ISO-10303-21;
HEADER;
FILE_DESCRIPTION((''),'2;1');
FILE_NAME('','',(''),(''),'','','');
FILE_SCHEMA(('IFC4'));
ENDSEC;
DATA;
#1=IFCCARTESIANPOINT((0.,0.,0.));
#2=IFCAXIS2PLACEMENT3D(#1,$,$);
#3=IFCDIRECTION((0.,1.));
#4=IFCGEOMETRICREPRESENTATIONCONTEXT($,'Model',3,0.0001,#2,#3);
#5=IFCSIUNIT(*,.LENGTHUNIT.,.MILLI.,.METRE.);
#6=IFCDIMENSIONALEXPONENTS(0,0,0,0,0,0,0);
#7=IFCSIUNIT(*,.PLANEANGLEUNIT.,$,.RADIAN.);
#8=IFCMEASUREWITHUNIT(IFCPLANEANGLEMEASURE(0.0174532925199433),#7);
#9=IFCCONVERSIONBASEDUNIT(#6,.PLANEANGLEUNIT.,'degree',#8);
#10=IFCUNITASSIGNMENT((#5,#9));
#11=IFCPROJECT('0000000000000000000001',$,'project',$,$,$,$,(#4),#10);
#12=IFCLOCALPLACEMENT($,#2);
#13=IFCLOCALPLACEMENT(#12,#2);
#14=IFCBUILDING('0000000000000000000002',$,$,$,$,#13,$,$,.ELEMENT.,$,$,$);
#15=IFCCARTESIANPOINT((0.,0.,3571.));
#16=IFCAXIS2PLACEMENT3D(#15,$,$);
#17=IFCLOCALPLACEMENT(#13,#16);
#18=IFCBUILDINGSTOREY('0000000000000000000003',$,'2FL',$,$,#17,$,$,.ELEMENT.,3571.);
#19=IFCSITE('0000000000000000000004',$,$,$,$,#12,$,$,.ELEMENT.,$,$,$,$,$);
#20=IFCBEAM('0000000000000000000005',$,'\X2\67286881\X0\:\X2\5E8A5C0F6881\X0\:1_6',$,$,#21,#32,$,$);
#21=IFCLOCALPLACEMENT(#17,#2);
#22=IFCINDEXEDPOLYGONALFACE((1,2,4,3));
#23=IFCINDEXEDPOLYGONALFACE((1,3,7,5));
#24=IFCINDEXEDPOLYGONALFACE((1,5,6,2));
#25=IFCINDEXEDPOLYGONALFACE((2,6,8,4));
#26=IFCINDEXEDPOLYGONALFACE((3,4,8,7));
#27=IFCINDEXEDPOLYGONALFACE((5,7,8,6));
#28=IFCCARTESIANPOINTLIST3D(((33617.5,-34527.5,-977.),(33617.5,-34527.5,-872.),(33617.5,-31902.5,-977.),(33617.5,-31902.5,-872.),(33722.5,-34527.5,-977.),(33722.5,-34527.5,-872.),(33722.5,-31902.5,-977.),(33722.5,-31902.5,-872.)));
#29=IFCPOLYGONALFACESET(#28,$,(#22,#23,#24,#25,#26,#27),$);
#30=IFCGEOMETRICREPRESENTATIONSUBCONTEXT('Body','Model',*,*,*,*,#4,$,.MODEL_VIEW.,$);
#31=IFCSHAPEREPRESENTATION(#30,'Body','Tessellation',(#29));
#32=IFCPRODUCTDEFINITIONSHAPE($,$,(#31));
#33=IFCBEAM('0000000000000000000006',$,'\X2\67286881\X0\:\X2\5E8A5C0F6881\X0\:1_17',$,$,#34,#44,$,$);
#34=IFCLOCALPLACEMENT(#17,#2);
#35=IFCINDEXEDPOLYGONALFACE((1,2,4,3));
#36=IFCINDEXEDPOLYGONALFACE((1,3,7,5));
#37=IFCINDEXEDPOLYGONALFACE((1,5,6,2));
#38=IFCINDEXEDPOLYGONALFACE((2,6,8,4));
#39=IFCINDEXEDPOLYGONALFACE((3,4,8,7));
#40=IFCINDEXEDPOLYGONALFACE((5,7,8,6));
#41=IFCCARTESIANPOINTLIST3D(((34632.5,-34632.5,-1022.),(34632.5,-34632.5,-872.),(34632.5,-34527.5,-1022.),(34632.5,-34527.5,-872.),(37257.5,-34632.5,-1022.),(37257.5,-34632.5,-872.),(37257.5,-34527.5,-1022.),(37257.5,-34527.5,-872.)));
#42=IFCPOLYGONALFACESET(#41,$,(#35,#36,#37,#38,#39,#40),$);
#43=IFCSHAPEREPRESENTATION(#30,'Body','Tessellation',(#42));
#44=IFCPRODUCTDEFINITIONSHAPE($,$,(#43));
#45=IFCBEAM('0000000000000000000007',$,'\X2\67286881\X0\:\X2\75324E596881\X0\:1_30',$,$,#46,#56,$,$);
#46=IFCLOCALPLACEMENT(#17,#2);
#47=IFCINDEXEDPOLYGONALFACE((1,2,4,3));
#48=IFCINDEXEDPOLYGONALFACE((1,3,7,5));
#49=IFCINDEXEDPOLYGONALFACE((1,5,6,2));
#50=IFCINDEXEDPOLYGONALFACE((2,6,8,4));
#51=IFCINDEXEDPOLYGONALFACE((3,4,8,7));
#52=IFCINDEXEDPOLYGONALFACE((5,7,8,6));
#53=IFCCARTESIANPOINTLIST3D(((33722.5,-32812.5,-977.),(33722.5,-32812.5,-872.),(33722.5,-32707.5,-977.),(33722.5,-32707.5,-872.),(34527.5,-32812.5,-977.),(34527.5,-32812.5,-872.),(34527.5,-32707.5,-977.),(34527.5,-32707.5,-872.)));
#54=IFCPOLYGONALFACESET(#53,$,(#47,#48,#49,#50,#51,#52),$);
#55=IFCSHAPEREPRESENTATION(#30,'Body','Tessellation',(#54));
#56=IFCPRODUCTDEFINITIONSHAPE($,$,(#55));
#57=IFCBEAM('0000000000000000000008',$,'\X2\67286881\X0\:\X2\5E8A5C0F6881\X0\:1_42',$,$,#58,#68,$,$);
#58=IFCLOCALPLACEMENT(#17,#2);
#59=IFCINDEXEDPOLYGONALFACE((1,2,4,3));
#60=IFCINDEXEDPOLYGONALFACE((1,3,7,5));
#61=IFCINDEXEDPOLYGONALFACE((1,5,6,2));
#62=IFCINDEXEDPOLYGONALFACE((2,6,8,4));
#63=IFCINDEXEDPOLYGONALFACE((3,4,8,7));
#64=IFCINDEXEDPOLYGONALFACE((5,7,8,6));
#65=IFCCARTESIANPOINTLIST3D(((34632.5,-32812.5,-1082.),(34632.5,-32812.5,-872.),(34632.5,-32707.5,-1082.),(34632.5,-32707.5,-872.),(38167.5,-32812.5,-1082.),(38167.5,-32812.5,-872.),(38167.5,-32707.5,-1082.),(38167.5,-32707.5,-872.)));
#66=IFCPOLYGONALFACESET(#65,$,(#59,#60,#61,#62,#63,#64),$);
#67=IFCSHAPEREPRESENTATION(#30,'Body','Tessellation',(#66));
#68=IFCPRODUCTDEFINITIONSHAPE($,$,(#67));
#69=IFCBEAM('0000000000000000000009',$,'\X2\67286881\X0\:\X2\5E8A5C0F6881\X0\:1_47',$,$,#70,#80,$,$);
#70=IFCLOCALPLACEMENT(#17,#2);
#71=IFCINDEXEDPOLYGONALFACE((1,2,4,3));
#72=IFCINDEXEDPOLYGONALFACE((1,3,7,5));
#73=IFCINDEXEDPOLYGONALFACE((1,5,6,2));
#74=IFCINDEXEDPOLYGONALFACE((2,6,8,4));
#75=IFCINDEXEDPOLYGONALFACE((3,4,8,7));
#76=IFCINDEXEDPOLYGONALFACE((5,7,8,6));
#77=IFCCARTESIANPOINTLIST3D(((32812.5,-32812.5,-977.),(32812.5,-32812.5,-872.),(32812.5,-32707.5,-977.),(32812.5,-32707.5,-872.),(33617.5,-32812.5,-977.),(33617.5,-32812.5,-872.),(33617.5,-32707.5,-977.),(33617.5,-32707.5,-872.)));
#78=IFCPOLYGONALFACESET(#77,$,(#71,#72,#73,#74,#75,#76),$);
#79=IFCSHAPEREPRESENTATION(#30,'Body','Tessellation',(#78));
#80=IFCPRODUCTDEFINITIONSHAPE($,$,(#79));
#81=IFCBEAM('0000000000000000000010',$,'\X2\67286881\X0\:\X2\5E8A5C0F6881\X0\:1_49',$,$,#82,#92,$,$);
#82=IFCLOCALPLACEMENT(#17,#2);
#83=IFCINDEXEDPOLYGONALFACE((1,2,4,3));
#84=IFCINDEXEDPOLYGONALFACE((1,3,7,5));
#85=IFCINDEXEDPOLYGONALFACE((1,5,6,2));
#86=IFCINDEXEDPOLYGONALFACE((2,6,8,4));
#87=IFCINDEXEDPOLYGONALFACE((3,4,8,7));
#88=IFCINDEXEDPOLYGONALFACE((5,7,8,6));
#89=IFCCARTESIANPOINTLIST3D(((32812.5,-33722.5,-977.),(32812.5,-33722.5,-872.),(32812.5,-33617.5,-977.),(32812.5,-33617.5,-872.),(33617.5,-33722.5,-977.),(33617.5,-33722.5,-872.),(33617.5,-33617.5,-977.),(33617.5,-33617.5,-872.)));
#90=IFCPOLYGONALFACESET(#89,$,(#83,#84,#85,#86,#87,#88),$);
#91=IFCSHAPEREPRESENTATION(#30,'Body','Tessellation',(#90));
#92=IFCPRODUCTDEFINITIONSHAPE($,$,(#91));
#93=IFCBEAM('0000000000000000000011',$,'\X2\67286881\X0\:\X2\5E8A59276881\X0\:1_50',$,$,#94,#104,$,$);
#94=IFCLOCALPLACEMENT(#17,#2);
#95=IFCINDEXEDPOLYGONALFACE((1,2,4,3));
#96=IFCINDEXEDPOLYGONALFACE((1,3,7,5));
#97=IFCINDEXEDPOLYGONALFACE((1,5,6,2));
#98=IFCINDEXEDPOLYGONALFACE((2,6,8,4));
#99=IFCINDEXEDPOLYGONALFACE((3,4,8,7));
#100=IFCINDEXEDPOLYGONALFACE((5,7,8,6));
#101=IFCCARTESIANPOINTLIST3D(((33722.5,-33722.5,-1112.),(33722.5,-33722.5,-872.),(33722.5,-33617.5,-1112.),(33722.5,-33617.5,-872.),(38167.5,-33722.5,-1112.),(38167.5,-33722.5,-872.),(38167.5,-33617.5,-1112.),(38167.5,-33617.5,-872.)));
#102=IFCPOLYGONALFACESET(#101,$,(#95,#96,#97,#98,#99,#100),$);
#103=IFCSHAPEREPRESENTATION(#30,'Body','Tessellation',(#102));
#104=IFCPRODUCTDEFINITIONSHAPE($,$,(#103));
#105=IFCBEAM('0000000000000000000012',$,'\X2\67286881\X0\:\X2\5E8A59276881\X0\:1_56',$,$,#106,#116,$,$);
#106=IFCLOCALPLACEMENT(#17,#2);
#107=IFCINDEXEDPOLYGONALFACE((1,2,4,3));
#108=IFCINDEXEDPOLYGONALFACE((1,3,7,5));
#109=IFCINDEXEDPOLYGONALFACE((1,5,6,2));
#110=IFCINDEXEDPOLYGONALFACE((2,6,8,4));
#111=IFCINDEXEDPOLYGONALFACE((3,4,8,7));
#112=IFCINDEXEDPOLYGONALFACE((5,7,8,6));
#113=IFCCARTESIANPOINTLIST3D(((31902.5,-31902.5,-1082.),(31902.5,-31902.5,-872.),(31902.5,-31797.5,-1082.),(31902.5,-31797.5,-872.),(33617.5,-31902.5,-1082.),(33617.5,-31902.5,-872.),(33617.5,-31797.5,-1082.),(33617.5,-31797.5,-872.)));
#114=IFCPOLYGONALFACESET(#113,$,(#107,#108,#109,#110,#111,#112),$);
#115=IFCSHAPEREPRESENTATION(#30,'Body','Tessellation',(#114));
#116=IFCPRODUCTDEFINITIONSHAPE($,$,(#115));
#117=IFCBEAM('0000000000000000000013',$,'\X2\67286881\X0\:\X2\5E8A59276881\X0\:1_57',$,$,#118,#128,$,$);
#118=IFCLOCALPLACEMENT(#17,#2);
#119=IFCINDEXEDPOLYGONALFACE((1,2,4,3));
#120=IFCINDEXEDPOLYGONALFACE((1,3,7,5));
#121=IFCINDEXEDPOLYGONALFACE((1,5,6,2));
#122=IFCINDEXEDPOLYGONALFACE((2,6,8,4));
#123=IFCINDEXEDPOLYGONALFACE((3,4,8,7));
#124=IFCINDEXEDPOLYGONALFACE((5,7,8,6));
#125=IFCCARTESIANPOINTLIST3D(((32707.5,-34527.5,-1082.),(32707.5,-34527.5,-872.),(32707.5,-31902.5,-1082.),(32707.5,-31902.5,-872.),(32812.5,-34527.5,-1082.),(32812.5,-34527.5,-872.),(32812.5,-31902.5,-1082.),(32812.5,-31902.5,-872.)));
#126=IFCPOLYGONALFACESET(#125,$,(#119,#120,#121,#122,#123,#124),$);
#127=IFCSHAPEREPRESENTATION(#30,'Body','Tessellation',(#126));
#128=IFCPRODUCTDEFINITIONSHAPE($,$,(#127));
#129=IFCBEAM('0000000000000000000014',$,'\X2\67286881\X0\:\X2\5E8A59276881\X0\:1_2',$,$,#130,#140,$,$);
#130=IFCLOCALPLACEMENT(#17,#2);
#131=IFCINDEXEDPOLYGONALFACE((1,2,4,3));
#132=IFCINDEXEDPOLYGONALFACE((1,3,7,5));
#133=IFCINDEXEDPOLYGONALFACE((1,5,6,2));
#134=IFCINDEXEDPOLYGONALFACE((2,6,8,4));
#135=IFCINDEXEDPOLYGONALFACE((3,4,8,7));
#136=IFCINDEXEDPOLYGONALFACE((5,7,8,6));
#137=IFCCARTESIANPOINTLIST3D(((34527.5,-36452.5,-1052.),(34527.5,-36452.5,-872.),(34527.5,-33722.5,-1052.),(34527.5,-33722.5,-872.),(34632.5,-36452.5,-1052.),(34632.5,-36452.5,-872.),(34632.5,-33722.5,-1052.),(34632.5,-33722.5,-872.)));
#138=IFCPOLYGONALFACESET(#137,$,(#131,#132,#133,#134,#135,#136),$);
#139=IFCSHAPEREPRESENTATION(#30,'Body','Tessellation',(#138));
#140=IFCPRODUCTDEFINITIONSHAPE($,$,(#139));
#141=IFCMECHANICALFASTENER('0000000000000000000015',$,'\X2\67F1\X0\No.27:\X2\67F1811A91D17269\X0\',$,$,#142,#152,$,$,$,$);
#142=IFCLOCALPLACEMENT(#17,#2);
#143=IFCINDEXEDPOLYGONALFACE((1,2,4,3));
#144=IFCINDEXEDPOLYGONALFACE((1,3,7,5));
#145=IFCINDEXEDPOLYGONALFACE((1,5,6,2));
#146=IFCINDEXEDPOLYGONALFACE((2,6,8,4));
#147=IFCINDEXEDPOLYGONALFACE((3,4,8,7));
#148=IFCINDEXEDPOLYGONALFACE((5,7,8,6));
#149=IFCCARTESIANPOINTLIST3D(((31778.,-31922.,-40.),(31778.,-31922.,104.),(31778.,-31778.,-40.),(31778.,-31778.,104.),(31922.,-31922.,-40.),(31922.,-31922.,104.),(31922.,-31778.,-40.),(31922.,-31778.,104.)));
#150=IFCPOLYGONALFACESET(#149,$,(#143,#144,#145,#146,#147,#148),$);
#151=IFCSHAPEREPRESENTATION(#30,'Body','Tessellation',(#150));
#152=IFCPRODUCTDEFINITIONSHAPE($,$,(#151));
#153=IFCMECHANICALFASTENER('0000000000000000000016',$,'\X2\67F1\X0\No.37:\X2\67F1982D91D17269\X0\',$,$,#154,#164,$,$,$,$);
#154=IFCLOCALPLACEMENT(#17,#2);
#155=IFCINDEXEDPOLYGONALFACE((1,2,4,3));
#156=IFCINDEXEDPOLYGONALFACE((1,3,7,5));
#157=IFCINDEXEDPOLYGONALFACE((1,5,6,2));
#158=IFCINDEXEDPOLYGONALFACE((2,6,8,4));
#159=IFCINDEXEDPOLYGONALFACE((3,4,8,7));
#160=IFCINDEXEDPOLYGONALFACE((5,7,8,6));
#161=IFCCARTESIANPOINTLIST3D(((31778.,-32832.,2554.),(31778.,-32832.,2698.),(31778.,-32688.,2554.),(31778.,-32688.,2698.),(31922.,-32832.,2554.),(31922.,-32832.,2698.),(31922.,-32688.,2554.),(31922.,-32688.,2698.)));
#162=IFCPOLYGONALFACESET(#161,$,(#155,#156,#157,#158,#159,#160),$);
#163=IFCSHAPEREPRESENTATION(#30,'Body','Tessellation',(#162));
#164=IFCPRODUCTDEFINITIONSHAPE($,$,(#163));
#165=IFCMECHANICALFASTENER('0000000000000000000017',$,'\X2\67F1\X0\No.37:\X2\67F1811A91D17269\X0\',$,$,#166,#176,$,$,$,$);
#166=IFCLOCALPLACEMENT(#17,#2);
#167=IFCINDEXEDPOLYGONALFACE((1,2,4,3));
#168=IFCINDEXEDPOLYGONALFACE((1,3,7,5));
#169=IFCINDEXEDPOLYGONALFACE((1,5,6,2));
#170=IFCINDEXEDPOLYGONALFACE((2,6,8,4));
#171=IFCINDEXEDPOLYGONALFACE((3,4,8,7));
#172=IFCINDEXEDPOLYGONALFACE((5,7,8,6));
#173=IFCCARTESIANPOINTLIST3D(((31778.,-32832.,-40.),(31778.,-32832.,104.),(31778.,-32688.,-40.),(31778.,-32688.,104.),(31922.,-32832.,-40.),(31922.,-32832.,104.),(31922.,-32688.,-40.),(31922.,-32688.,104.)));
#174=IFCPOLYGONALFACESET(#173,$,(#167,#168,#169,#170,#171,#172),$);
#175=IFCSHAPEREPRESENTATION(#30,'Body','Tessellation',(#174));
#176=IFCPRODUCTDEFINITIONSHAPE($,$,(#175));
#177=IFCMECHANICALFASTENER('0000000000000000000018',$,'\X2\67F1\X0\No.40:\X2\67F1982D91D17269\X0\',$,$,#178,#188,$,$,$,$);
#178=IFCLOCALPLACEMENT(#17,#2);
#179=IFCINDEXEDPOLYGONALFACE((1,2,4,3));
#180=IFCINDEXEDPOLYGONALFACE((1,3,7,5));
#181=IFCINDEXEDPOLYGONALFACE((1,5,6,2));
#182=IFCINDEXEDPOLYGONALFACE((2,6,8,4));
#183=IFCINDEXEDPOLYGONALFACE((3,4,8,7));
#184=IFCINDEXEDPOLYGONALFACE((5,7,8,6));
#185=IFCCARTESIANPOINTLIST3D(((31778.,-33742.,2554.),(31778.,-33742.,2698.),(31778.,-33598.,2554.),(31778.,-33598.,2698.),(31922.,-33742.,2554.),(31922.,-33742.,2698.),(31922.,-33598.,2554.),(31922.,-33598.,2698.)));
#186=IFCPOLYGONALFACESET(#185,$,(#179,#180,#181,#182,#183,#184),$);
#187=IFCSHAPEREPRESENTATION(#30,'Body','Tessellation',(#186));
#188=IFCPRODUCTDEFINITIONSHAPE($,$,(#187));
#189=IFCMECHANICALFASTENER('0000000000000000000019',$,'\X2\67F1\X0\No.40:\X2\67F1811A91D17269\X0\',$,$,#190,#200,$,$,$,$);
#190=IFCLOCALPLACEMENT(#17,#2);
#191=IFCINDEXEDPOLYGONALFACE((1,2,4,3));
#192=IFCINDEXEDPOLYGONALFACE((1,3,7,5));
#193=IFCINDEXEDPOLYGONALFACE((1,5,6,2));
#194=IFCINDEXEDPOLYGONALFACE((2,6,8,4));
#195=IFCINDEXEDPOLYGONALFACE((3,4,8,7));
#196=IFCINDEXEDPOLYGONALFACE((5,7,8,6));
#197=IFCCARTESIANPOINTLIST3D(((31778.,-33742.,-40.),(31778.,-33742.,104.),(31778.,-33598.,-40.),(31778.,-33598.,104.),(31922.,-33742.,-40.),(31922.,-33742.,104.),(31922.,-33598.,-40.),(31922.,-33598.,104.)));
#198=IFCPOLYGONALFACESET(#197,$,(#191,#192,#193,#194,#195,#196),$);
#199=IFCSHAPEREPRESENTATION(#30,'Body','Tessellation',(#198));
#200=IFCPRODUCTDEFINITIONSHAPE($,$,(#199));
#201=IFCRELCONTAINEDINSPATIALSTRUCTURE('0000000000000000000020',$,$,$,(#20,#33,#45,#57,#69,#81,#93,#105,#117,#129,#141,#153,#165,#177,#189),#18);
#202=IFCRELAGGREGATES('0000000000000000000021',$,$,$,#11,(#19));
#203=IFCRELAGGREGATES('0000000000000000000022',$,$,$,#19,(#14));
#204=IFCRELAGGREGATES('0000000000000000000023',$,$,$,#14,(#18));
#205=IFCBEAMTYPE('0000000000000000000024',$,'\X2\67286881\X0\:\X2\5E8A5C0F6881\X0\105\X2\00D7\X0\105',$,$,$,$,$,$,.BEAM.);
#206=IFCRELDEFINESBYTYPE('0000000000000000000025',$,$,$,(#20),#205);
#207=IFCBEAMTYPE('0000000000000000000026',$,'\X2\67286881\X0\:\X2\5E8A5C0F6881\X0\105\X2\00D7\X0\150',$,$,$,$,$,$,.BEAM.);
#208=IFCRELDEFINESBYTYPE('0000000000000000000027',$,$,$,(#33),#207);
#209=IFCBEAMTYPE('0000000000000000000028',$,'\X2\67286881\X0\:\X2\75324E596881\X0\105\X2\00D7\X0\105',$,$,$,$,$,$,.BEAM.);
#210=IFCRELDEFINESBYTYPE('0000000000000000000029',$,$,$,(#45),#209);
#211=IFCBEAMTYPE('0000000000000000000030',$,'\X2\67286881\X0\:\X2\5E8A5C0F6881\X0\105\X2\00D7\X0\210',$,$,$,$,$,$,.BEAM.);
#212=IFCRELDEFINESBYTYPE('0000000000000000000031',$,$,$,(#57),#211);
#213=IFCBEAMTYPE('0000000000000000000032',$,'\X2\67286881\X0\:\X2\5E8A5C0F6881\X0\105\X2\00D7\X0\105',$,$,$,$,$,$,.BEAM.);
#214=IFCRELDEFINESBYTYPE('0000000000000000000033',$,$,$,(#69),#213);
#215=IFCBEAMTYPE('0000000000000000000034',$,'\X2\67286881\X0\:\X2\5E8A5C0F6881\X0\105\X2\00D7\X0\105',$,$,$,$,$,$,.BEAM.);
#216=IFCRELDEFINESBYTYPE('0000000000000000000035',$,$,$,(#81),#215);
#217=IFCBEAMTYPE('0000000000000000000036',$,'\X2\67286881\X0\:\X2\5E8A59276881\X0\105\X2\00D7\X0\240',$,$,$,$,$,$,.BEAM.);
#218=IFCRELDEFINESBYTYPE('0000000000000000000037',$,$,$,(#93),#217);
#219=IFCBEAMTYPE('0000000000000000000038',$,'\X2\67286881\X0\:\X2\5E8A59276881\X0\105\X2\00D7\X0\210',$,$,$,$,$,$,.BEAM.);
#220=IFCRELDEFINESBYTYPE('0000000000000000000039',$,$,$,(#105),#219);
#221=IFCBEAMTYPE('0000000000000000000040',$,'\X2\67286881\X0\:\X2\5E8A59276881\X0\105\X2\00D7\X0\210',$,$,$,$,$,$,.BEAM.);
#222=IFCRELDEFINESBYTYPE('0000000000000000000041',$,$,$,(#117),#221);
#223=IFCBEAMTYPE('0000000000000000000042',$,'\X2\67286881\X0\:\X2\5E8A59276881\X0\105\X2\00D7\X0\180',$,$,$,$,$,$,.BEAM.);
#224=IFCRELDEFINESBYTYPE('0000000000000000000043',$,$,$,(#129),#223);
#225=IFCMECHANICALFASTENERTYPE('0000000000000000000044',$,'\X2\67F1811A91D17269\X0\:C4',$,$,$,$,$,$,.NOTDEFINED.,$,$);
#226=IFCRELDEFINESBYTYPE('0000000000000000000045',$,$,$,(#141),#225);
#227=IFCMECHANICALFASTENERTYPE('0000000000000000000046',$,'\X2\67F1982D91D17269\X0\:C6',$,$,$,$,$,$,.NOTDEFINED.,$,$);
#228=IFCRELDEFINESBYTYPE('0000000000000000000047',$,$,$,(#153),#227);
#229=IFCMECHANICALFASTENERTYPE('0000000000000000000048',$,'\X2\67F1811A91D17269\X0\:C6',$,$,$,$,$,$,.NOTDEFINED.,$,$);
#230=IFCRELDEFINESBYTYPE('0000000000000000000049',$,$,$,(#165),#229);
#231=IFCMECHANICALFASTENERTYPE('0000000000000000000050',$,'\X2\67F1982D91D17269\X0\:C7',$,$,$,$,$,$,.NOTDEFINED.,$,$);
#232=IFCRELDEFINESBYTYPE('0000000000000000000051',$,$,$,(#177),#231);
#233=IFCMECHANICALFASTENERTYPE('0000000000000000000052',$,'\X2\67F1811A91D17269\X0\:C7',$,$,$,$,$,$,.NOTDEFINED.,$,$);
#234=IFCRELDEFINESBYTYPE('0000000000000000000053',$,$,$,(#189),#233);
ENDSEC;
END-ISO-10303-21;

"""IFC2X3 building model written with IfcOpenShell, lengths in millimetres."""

from ifc_helpers import new_model, entity, si_unit, converted_unit, direction, frame, origin, origin_with_axes, origin_2d, place, context, subcontext, project, spatial, rectangle, extrude, type_object, element, save


model = new_model("IFC2X3")

# Units and contexts
model_context = context("Model", 3, precision=0.0001, world=origin(), true_north=direction((0.0, 1.0)))
body_context = subcontext(model_context, "Body", "Model", "MODEL_VIEW")
ifc_project = project(units=[si_unit("LENGTHUNIT", "METRE", prefix="MILLI"), converted_unit("PLANEANGLEUNIT", "degree", entity("IfcPlaneAngleMeasure", 0.0174532925199433), si_unit("PLANEANGLEUNIT", "RADIAN"), dimensions=[0, 0, 0, 0, 0, 0, 0])], contexts=[model_context])

# Site, building, storey
site_placement = place(None, origin())
site = spatial("IfcSite", under=ifc_project, at=site_placement, CompositionType="ELEMENT")
building_placement = place(site_placement, origin())
building = spatial("IfcBuilding", under=site, at=building_placement, CompositionType="ELEMENT")
storey_placement = place(building_placement, frame((0.0, 0.0, 3571.0)))
storey = spatial("IfcBuildingStorey", under=building, at=storey_placement, Name="2FL", CompositionType="ELEMENT", Elevation=3571.0)

# Beams
beam_type_1 = type_object("IfcBeamType", Name="木梁:床小梁105×105", PredefinedType="BEAM")
beam_1_placement = place(storey_placement, frame((33670.0, -31902.5, -924.5), z_axis=(0.0, -1.0, 0.0), x_axis=(1.0, 0.0, 0.0)))
element("IfcBeam", 1, at=beam_1_placement, inside=storey, type_object=beam_type_1, Name="木梁:床小梁:1_6", context=body_context, shape_type="SweptSolid", body=[
    extrude(rectangle(XDim=105.0, YDim=105.0, at=origin_2d()), origin_with_axes(), (0.0, 0.0, 1.0), 2625.0),
])
beam_type_2 = type_object("IfcBeamType", Name="木梁:床小梁105×150", PredefinedType="BEAM")
beam_2_placement = place(storey_placement, frame((34632.5, -34580.0, -947.0), z_axis=(1.0, 0.0, 0.0), x_axis=(0.0, 1.0, 0.0)))
element("IfcBeam", 2, at=beam_2_placement, inside=storey, type_object=beam_type_2, Name="木梁:床小梁:1_17", context=body_context, shape_type="SweptSolid", body=[
    extrude(rectangle(XDim=105.0, YDim=150.0, at=origin_2d()), origin_with_axes(), (0.0, 0.0, 1.0), 2625.0),
])
beam_type_3 = type_object("IfcBeamType", Name="木梁:甲乙梁105×105", PredefinedType="BEAM")
beam_3_placement = place(storey_placement, frame((33722.5, -32760.0, -924.5), z_axis=(1.0, 0.0, 0.0), x_axis=(0.0, 1.0, 0.0)))
element("IfcBeam", 3, at=beam_3_placement, inside=storey, type_object=beam_type_3, Name="木梁:甲乙梁:1_30", context=body_context, shape_type="SweptSolid", body=[
    extrude(rectangle(XDim=105.0, YDim=105.0, at=origin_2d()), origin_with_axes(), (0.0, 0.0, 1.0), 805.0),
])
beam_type_4 = type_object("IfcBeamType", Name="木梁:床小梁105×210", PredefinedType="BEAM")
beam_4_placement = place(storey_placement, frame((34632.5, -32760.0, -977.0), z_axis=(1.0, 0.0, 0.0), x_axis=(0.0, 1.0, 0.0)))
element("IfcBeam", 4, at=beam_4_placement, inside=storey, type_object=beam_type_4, Name="木梁:床小梁:1_42", context=body_context, shape_type="SweptSolid", body=[
    extrude(rectangle(XDim=105.0, YDim=210.0, at=origin_2d()), origin_with_axes(), (0.0, 0.0, 1.0), 3535.0),
])
beam_type_5 = type_object("IfcBeamType", Name="木梁:床小梁105×105", PredefinedType="BEAM")
beam_5_placement = place(storey_placement, frame((32812.5, -32760.0, -924.5), z_axis=(1.0, 0.0, 0.0), x_axis=(0.0, 1.0, 0.0)))
element("IfcBeam", 5, at=beam_5_placement, inside=storey, type_object=beam_type_5, Name="木梁:床小梁:1_47", context=body_context, shape_type="SweptSolid", body=[
    extrude(rectangle(XDim=105.0, YDim=105.0, at=origin_2d()), origin_with_axes(), (0.0, 0.0, 1.0), 805.0),
])
beam_type_6 = type_object("IfcBeamType", Name="木梁:床小梁105×105", PredefinedType="BEAM")
beam_6_placement = place(storey_placement, frame((32812.5, -33670.0, -924.5), z_axis=(1.0, 0.0, 0.0), x_axis=(0.0, 1.0, 0.0)))
element("IfcBeam", 6, at=beam_6_placement, inside=storey, type_object=beam_type_6, Name="木梁:床小梁:1_49", context=body_context, shape_type="SweptSolid", body=[
    extrude(rectangle(XDim=105.0, YDim=105.0, at=origin_2d()), origin_with_axes(), (0.0, 0.0, 1.0), 805.0),
])
beam_type_7 = type_object("IfcBeamType", Name="木梁:床大梁105×240", PredefinedType="BEAM")
beam_7_placement = place(storey_placement, frame((33722.5, -33670.0, -992.0), z_axis=(1.0, 0.0, 0.0), x_axis=(0.0, 1.0, 0.0)))
element("IfcBeam", 7, at=beam_7_placement, inside=storey, type_object=beam_type_7, Name="木梁:床大梁:1_50", context=body_context, shape_type="SweptSolid", body=[
    extrude(rectangle(XDim=105.0, YDim=240.0, at=origin_2d()), origin_with_axes(), (0.0, 0.0, 1.0), 4445.0),
])
beam_type_8 = type_object("IfcBeamType", Name="木梁:床大梁105×210", PredefinedType="BEAM")
beam_8_placement = place(storey_placement, frame((31902.5, -31850.0, -977.0), z_axis=(1.0, 0.0, 0.0), x_axis=(0.0, 1.0, 0.0)))
element("IfcBeam", 8, at=beam_8_placement, inside=storey, type_object=beam_type_8, Name="木梁:床大梁:1_56", context=body_context, shape_type="SweptSolid", body=[
    extrude(rectangle(XDim=105.0, YDim=210.0, at=origin_2d()), origin_with_axes(), (0.0, 0.0, 1.0), 1715.0),
])
beam_type_9 = type_object("IfcBeamType", Name="木梁:床大梁105×210", PredefinedType="BEAM")
beam_9_placement = place(storey_placement, frame((32760.0, -31902.5, -977.0), z_axis=(0.0, -1.0, 0.0), x_axis=(1.0, 0.0, 0.0)))
element("IfcBeam", 9, at=beam_9_placement, inside=storey, type_object=beam_type_9, Name="木梁:床大梁:1_57", context=body_context, shape_type="SweptSolid", body=[
    extrude(rectangle(XDim=105.0, YDim=210.0, at=origin_2d()), origin_with_axes(), (0.0, 0.0, 1.0), 2625.0),
])
beam_type_10 = type_object("IfcBeamType", Name="木梁:床大梁105×180", PredefinedType="BEAM")
beam_10_placement = place(storey_placement, frame((34580.0, -33722.5, -962.0), z_axis=(0.0, -1.0, 0.0), x_axis=(1.0, 0.0, 0.0)))
element("IfcBeam", 10, at=beam_10_placement, inside=storey, type_object=beam_type_10, Name="木梁:床大梁:1_2", context=body_context, shape_type="SweptSolid", body=[
    extrude(rectangle(XDim=105.0, YDim=180.0, at=origin_2d()), origin_with_axes(), (0.0, 0.0, 1.0), 2730.0),
])

# Mechanical fasteners
mechanical_fastener_type_1 = type_object("IfcMechanicalFastenerType", Name="柱脚金物:C4")
mechanical_fastener_1_placement = place(storey_placement, frame((31850.0, -31850.0, -40.0)))
element("IfcMechanicalFastener", 11, at=mechanical_fastener_1_placement, inside=storey, type_object=mechanical_fastener_type_1, Name="柱No.27:柱脚金物", context=body_context, shape_type="SweptSolid", body=[
    extrude(rectangle(XDim=144.0, YDim=144.0, at=origin_2d()), origin_with_axes(), (0.0, 0.0, 1.0), 144.0),
])
mechanical_fastener_type_2 = type_object("IfcMechanicalFastenerType", Name="柱頭金物:C6")
mechanical_fastener_2_placement = place(storey_placement, frame((31850.0, -32760.0, 2554.0)))
element("IfcMechanicalFastener", 12, at=mechanical_fastener_2_placement, inside=storey, type_object=mechanical_fastener_type_2, Name="柱No.37:柱頭金物", context=body_context, shape_type="SweptSolid", body=[
    extrude(rectangle(XDim=144.0, YDim=144.0, at=origin_2d()), origin_with_axes(), (0.0, 0.0, 1.0), 144.0),
])
mechanical_fastener_type_3 = type_object("IfcMechanicalFastenerType", Name="柱脚金物:C6")
mechanical_fastener_3_placement = place(storey_placement, frame((31850.0, -32760.0, -40.0)))
element("IfcMechanicalFastener", 13, at=mechanical_fastener_3_placement, inside=storey, type_object=mechanical_fastener_type_3, Name="柱No.37:柱脚金物", context=body_context, shape_type="SweptSolid", body=[
    extrude(rectangle(XDim=144.0, YDim=144.0, at=origin_2d()), origin_with_axes(), (0.0, 0.0, 1.0), 144.0),
])
mechanical_fastener_type_4 = type_object("IfcMechanicalFastenerType", Name="柱頭金物:C7")
mechanical_fastener_4_placement = place(storey_placement, frame((31850.0, -33670.0, 2554.0)))
element("IfcMechanicalFastener", 14, at=mechanical_fastener_4_placement, inside=storey, type_object=mechanical_fastener_type_4, Name="柱No.40:柱頭金物", context=body_context, shape_type="SweptSolid", body=[
    extrude(rectangle(XDim=144.0, YDim=144.0, at=origin_2d()), origin_with_axes(), (0.0, 0.0, 1.0), 144.0),
])
mechanical_fastener_type_5 = type_object("IfcMechanicalFastenerType", Name="柱脚金物:C7")
mechanical_fastener_5_placement = place(storey_placement, frame((31850.0, -33670.0, -40.0)))
element("IfcMechanicalFastener", 15, at=mechanical_fastener_5_placement, inside=storey, type_object=mechanical_fastener_type_5, Name="柱No.40:柱脚金物", context=body_context, shape_type="SweptSolid", body=[
    extrude(rectangle(XDim=144.0, YDim=144.0, at=origin_2d()), origin_with_axes(), (0.0, 0.0, 1.0), 144.0),
])

save(model, "model.ifc")
